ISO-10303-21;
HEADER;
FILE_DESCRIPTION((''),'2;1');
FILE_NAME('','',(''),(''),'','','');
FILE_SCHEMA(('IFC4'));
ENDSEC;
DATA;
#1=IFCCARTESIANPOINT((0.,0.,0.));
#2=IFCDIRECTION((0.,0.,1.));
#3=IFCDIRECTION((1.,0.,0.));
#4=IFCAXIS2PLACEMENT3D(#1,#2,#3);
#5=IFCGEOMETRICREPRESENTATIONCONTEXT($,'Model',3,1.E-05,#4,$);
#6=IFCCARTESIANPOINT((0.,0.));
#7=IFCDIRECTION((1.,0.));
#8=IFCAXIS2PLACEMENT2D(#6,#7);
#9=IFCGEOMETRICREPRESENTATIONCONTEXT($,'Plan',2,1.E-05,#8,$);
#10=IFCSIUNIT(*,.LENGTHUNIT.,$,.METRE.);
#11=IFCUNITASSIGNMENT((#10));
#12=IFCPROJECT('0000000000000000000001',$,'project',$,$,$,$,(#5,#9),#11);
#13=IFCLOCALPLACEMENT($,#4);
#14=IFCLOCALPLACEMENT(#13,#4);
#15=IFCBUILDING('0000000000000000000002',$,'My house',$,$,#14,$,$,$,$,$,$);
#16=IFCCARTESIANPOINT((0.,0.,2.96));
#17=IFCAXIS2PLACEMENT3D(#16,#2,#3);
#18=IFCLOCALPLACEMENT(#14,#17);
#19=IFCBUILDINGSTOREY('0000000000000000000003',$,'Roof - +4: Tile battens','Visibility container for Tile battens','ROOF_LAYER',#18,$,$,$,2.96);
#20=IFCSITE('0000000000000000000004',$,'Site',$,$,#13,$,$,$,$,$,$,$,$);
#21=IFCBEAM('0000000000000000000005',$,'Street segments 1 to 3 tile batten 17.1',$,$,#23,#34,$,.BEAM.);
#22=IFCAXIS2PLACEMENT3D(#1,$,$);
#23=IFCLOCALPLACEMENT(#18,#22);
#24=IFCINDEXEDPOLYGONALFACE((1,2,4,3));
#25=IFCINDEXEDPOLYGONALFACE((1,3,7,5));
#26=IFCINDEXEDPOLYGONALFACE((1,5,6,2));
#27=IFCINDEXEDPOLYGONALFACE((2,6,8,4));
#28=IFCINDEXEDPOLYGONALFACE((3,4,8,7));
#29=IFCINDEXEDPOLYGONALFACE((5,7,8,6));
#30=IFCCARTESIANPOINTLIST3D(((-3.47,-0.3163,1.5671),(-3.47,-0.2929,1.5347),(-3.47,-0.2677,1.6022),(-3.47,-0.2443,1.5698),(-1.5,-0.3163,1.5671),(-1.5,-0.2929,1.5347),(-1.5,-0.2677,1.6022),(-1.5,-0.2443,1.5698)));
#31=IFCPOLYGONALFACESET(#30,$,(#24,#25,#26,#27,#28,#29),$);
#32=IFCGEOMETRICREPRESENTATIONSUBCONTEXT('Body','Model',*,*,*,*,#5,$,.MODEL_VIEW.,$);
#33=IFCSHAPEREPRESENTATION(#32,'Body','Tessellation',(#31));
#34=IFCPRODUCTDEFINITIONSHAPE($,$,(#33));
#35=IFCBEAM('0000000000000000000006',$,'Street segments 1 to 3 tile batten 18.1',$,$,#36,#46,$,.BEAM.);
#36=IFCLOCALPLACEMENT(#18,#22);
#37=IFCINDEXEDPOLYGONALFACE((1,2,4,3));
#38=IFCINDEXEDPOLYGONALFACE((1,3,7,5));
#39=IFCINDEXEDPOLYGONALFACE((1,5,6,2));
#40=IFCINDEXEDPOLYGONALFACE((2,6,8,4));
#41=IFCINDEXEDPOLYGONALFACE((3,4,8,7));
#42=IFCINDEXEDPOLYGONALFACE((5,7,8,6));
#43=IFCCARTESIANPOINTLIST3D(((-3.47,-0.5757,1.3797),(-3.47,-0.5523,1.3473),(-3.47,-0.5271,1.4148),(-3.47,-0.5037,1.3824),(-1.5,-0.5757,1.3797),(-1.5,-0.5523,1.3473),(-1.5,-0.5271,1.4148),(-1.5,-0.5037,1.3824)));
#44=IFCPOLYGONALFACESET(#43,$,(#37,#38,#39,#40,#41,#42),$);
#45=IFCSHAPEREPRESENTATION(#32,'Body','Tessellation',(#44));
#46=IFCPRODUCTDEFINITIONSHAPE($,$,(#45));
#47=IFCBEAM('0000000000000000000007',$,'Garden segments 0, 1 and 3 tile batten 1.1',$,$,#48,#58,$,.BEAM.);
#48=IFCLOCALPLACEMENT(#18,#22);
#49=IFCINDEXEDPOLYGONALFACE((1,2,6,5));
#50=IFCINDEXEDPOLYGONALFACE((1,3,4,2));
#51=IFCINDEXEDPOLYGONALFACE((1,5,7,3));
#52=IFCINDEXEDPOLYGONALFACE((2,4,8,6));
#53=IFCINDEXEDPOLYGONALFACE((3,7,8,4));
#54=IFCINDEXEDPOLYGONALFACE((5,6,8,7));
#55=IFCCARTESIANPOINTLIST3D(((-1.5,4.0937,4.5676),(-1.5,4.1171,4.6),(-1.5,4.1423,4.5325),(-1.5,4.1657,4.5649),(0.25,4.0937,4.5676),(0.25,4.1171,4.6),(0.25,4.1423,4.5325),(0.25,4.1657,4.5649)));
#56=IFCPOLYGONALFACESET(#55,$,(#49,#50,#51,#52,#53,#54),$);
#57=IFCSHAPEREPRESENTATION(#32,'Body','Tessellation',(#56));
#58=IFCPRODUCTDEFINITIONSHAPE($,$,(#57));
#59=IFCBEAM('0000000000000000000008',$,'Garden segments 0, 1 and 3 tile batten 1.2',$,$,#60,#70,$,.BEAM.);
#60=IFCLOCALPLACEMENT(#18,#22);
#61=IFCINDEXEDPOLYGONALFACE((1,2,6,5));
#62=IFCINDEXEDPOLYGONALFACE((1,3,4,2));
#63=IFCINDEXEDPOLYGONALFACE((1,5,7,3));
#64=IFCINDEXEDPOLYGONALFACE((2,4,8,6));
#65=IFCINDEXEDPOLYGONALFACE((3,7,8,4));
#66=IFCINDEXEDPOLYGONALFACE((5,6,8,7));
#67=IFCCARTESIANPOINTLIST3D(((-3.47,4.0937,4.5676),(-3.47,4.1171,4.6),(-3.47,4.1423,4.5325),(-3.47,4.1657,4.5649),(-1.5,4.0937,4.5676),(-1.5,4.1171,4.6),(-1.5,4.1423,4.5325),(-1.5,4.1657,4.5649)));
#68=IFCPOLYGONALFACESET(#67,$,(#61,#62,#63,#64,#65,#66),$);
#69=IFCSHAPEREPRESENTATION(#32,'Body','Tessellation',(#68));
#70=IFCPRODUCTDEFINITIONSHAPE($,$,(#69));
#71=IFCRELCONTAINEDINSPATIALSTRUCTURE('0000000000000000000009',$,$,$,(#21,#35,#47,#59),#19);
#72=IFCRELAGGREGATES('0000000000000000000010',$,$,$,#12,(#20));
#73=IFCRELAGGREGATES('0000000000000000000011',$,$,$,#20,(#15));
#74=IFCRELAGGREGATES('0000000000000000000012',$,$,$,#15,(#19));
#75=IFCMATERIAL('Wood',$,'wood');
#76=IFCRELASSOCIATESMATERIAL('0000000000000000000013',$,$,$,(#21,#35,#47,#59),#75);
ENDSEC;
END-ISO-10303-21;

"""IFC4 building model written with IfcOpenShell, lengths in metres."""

from ifc_helpers import new_model, si_unit, frame, origin_with_axes, origin_2d_with_axis, place, context, subcontext, project, spatial, rectangle, extrude, clip, halfspace, source, transform, mapped, material, element, save


model = new_model("IFC4")

# Units and contexts
model_context = context("Model", 3, precision=1e-05, world=origin_with_axes())
plan_context = context("Plan", 2, precision=1e-05, world=origin_2d_with_axis())
body_context = subcontext(model_context, "Body", "Model", "MODEL_VIEW")
ifc_project = project(units=[si_unit("LENGTHUNIT", "METRE")], contexts=[model_context, plan_context])

# Site, building, storey
site_placement = place(None, origin_with_axes())
site = spatial("IfcSite", under=ifc_project, at=site_placement, Name="Site")
building_placement = place(site_placement, origin_with_axes())
building = spatial("IfcBuilding", under=site, at=building_placement, Name="My house")
storey_placement = place(building_placement, frame((0.0, 0.0, 2.96), z_axis=(0.0, 0.0, 1.0), x_axis=(1.0, 0.0, 0.0)))
storey = spatial("IfcBuildingStorey", under=building, at=storey_placement, Name="Roof - +4: Tile battens", Description="Visibility container for Tile battens", ObjectType="ROOF_LAYER", Elevation=2.96)

# Beams
ifc_material = material(Name="Wood", Category="wood")
shared_shape_1 = source(origin_with_axes(), body_context, "Body", "Clipping", [
    clip(clip(extrude(rectangle(XDim=0.06, YDim=0.04), frame((0.0, 0.0, 0.0), z_axis=(1.0, 0.0, 0.0), x_axis=(0.0, 1.0, 0.0)), (0.0, 0.0, 1.0), 1.97), halfspace(frame((-1.5, 0.8184, -6.1772), z_axis=(0.0, 0.810664, -0.585512), x_axis=(1.0, 0.0, 0.0)), False)), halfspace(frame((-1.5, -3.0322, -3.396), z_axis=(0.0, -0.810664, 0.585512), x_axis=(-1.0, 0.0, 0.0)), False)),
])
beam_1_placement = place(storey_placement, frame((-1.5, -0.2803, 1.5684), z_axis=(0.0, -0.585512, 0.810664), x_axis=(1.0, 0.0, 0.0)))
element("IfcBeam", 1, at=beam_1_placement, inside=storey, material=ifc_material, Name="Street segments 1 to 3 tile batten 17.1", PredefinedType="BEAM", context=body_context, shape_type="MappedRepresentation", body=[
    mapped(shared_shape_1, transform((0.0, 0.0, 0.0), x_axis=(-1.0, 0.0, 0.0), y_axis=(0.0, 1.0, 0.0), z_axis=(0.0, 0.0, 1.0), scale=1.0)),
])
shared_shape_2 = source(origin_with_axes(), body_context, "Body", "Clipping", [
    clip(clip(extrude(rectangle(XDim=0.06, YDim=0.04), frame((0.0, 0.0, 0.0), z_axis=(1.0, 0.0, 0.0), x_axis=(0.0, 1.0, 0.0)), (0.0, 0.0, 1.0), 1.97), halfspace(frame((-1.5, 1.1384, -6.1772), z_axis=(0.0, 0.810664, -0.585512), x_axis=(1.0, 0.0, 0.0)), False)), halfspace(frame((-1.5, -2.7122, -3.396), z_axis=(0.0, -0.810664, 0.585512), x_axis=(-1.0, 0.0, 0.0)), False)),
])
beam_2_placement = place(storey_placement, frame((-1.5, -0.5397, 1.3811), z_axis=(0.0, -0.585512, 0.810664), x_axis=(1.0, 0.0, 0.0)))
element("IfcBeam", 2, at=beam_2_placement, inside=storey, material=ifc_material, Name="Street segments 1 to 3 tile batten 18.1", PredefinedType="BEAM", context=body_context, shape_type="MappedRepresentation", body=[
    mapped(shared_shape_2, transform((0.0, 0.0, 0.0), x_axis=(-1.0, 0.0, 0.0), y_axis=(0.0, 1.0, 0.0), z_axis=(0.0, 0.0, 1.0), scale=1.0)),
])
shared_shape_3 = source(origin_with_axes(), body_context, "Body", "Clipping", [
    clip(clip(extrude(rectangle(XDim=0.06, YDim=0.04), frame((0.0, 0.0, 0.0), z_axis=(1.0, 0.0, 0.0), x_axis=(0.0, 1.0, 0.0)), (0.0, 0.0, 1.0), 1.75), halfspace(frame((0.25, 4.3016, -6.1772), z_axis=(0.0, -0.810664, -0.585512), x_axis=(-1.0, 0.0, 0.0)), False)), halfspace(frame((0.25, 8.1522, -3.396), z_axis=(0.0, 0.810664, 0.585512), x_axis=(1.0, 0.0, 0.0)), False)),
])
beam_3_placement = place(storey_placement, frame((0.25, 4.1297, 4.5663), z_axis=(0.0, 0.585512, 0.810664), x_axis=(1.0, 0.0, 0.0)))
element("IfcBeam", 3, at=beam_3_placement, inside=storey, material=ifc_material, Name="Garden segments 0, 1 and 3 tile batten 1.1", PredefinedType="BEAM", context=body_context, shape_type="MappedRepresentation", body=[
    mapped(shared_shape_3, transform((0.0, 0.0, 0.0), x_axis=(-1.0, 0.0, 0.0), y_axis=(0.0, 1.0, 0.0), z_axis=(0.0, 0.0, 1.0), scale=1.0)),
])
shared_shape_4 = source(origin_with_axes(), body_context, "Body", "Clipping", [
    clip(clip(extrude(rectangle(XDim=0.06, YDim=0.04), frame((0.0, 0.0, 0.0), z_axis=(1.0, 0.0, 0.0), x_axis=(0.0, 1.0, 0.0)), (0.0, 0.0, 1.0), 1.97), halfspace(frame((-1.5, 4.3016, -6.1772), z_axis=(0.0, -0.810664, -0.585512), x_axis=(-1.0, 0.0, 0.0)), False)), halfspace(frame((-1.5, 8.1522, -3.396), z_axis=(0.0, 0.810664, 0.585512), x_axis=(1.0, 0.0, 0.0)), False)),
])
beam_4_placement = place(storey_placement, frame((-1.5, 4.1297, 4.5663), z_axis=(0.0, 0.585512, 0.810664), x_axis=(1.0, 0.0, 0.0)))
element("IfcBeam", 4, at=beam_4_placement, inside=storey, material=ifc_material, Name="Garden segments 0, 1 and 3 tile batten 1.2", PredefinedType="BEAM", context=body_context, shape_type="MappedRepresentation", body=[
    mapped(shared_shape_4, transform((0.0, 0.0, 0.0), x_axis=(-1.0, 0.0, 0.0), y_axis=(0.0, 1.0, 0.0), z_axis=(0.0, 0.0, 1.0), scale=1.0)),
])

save(model, "model.ifc")
